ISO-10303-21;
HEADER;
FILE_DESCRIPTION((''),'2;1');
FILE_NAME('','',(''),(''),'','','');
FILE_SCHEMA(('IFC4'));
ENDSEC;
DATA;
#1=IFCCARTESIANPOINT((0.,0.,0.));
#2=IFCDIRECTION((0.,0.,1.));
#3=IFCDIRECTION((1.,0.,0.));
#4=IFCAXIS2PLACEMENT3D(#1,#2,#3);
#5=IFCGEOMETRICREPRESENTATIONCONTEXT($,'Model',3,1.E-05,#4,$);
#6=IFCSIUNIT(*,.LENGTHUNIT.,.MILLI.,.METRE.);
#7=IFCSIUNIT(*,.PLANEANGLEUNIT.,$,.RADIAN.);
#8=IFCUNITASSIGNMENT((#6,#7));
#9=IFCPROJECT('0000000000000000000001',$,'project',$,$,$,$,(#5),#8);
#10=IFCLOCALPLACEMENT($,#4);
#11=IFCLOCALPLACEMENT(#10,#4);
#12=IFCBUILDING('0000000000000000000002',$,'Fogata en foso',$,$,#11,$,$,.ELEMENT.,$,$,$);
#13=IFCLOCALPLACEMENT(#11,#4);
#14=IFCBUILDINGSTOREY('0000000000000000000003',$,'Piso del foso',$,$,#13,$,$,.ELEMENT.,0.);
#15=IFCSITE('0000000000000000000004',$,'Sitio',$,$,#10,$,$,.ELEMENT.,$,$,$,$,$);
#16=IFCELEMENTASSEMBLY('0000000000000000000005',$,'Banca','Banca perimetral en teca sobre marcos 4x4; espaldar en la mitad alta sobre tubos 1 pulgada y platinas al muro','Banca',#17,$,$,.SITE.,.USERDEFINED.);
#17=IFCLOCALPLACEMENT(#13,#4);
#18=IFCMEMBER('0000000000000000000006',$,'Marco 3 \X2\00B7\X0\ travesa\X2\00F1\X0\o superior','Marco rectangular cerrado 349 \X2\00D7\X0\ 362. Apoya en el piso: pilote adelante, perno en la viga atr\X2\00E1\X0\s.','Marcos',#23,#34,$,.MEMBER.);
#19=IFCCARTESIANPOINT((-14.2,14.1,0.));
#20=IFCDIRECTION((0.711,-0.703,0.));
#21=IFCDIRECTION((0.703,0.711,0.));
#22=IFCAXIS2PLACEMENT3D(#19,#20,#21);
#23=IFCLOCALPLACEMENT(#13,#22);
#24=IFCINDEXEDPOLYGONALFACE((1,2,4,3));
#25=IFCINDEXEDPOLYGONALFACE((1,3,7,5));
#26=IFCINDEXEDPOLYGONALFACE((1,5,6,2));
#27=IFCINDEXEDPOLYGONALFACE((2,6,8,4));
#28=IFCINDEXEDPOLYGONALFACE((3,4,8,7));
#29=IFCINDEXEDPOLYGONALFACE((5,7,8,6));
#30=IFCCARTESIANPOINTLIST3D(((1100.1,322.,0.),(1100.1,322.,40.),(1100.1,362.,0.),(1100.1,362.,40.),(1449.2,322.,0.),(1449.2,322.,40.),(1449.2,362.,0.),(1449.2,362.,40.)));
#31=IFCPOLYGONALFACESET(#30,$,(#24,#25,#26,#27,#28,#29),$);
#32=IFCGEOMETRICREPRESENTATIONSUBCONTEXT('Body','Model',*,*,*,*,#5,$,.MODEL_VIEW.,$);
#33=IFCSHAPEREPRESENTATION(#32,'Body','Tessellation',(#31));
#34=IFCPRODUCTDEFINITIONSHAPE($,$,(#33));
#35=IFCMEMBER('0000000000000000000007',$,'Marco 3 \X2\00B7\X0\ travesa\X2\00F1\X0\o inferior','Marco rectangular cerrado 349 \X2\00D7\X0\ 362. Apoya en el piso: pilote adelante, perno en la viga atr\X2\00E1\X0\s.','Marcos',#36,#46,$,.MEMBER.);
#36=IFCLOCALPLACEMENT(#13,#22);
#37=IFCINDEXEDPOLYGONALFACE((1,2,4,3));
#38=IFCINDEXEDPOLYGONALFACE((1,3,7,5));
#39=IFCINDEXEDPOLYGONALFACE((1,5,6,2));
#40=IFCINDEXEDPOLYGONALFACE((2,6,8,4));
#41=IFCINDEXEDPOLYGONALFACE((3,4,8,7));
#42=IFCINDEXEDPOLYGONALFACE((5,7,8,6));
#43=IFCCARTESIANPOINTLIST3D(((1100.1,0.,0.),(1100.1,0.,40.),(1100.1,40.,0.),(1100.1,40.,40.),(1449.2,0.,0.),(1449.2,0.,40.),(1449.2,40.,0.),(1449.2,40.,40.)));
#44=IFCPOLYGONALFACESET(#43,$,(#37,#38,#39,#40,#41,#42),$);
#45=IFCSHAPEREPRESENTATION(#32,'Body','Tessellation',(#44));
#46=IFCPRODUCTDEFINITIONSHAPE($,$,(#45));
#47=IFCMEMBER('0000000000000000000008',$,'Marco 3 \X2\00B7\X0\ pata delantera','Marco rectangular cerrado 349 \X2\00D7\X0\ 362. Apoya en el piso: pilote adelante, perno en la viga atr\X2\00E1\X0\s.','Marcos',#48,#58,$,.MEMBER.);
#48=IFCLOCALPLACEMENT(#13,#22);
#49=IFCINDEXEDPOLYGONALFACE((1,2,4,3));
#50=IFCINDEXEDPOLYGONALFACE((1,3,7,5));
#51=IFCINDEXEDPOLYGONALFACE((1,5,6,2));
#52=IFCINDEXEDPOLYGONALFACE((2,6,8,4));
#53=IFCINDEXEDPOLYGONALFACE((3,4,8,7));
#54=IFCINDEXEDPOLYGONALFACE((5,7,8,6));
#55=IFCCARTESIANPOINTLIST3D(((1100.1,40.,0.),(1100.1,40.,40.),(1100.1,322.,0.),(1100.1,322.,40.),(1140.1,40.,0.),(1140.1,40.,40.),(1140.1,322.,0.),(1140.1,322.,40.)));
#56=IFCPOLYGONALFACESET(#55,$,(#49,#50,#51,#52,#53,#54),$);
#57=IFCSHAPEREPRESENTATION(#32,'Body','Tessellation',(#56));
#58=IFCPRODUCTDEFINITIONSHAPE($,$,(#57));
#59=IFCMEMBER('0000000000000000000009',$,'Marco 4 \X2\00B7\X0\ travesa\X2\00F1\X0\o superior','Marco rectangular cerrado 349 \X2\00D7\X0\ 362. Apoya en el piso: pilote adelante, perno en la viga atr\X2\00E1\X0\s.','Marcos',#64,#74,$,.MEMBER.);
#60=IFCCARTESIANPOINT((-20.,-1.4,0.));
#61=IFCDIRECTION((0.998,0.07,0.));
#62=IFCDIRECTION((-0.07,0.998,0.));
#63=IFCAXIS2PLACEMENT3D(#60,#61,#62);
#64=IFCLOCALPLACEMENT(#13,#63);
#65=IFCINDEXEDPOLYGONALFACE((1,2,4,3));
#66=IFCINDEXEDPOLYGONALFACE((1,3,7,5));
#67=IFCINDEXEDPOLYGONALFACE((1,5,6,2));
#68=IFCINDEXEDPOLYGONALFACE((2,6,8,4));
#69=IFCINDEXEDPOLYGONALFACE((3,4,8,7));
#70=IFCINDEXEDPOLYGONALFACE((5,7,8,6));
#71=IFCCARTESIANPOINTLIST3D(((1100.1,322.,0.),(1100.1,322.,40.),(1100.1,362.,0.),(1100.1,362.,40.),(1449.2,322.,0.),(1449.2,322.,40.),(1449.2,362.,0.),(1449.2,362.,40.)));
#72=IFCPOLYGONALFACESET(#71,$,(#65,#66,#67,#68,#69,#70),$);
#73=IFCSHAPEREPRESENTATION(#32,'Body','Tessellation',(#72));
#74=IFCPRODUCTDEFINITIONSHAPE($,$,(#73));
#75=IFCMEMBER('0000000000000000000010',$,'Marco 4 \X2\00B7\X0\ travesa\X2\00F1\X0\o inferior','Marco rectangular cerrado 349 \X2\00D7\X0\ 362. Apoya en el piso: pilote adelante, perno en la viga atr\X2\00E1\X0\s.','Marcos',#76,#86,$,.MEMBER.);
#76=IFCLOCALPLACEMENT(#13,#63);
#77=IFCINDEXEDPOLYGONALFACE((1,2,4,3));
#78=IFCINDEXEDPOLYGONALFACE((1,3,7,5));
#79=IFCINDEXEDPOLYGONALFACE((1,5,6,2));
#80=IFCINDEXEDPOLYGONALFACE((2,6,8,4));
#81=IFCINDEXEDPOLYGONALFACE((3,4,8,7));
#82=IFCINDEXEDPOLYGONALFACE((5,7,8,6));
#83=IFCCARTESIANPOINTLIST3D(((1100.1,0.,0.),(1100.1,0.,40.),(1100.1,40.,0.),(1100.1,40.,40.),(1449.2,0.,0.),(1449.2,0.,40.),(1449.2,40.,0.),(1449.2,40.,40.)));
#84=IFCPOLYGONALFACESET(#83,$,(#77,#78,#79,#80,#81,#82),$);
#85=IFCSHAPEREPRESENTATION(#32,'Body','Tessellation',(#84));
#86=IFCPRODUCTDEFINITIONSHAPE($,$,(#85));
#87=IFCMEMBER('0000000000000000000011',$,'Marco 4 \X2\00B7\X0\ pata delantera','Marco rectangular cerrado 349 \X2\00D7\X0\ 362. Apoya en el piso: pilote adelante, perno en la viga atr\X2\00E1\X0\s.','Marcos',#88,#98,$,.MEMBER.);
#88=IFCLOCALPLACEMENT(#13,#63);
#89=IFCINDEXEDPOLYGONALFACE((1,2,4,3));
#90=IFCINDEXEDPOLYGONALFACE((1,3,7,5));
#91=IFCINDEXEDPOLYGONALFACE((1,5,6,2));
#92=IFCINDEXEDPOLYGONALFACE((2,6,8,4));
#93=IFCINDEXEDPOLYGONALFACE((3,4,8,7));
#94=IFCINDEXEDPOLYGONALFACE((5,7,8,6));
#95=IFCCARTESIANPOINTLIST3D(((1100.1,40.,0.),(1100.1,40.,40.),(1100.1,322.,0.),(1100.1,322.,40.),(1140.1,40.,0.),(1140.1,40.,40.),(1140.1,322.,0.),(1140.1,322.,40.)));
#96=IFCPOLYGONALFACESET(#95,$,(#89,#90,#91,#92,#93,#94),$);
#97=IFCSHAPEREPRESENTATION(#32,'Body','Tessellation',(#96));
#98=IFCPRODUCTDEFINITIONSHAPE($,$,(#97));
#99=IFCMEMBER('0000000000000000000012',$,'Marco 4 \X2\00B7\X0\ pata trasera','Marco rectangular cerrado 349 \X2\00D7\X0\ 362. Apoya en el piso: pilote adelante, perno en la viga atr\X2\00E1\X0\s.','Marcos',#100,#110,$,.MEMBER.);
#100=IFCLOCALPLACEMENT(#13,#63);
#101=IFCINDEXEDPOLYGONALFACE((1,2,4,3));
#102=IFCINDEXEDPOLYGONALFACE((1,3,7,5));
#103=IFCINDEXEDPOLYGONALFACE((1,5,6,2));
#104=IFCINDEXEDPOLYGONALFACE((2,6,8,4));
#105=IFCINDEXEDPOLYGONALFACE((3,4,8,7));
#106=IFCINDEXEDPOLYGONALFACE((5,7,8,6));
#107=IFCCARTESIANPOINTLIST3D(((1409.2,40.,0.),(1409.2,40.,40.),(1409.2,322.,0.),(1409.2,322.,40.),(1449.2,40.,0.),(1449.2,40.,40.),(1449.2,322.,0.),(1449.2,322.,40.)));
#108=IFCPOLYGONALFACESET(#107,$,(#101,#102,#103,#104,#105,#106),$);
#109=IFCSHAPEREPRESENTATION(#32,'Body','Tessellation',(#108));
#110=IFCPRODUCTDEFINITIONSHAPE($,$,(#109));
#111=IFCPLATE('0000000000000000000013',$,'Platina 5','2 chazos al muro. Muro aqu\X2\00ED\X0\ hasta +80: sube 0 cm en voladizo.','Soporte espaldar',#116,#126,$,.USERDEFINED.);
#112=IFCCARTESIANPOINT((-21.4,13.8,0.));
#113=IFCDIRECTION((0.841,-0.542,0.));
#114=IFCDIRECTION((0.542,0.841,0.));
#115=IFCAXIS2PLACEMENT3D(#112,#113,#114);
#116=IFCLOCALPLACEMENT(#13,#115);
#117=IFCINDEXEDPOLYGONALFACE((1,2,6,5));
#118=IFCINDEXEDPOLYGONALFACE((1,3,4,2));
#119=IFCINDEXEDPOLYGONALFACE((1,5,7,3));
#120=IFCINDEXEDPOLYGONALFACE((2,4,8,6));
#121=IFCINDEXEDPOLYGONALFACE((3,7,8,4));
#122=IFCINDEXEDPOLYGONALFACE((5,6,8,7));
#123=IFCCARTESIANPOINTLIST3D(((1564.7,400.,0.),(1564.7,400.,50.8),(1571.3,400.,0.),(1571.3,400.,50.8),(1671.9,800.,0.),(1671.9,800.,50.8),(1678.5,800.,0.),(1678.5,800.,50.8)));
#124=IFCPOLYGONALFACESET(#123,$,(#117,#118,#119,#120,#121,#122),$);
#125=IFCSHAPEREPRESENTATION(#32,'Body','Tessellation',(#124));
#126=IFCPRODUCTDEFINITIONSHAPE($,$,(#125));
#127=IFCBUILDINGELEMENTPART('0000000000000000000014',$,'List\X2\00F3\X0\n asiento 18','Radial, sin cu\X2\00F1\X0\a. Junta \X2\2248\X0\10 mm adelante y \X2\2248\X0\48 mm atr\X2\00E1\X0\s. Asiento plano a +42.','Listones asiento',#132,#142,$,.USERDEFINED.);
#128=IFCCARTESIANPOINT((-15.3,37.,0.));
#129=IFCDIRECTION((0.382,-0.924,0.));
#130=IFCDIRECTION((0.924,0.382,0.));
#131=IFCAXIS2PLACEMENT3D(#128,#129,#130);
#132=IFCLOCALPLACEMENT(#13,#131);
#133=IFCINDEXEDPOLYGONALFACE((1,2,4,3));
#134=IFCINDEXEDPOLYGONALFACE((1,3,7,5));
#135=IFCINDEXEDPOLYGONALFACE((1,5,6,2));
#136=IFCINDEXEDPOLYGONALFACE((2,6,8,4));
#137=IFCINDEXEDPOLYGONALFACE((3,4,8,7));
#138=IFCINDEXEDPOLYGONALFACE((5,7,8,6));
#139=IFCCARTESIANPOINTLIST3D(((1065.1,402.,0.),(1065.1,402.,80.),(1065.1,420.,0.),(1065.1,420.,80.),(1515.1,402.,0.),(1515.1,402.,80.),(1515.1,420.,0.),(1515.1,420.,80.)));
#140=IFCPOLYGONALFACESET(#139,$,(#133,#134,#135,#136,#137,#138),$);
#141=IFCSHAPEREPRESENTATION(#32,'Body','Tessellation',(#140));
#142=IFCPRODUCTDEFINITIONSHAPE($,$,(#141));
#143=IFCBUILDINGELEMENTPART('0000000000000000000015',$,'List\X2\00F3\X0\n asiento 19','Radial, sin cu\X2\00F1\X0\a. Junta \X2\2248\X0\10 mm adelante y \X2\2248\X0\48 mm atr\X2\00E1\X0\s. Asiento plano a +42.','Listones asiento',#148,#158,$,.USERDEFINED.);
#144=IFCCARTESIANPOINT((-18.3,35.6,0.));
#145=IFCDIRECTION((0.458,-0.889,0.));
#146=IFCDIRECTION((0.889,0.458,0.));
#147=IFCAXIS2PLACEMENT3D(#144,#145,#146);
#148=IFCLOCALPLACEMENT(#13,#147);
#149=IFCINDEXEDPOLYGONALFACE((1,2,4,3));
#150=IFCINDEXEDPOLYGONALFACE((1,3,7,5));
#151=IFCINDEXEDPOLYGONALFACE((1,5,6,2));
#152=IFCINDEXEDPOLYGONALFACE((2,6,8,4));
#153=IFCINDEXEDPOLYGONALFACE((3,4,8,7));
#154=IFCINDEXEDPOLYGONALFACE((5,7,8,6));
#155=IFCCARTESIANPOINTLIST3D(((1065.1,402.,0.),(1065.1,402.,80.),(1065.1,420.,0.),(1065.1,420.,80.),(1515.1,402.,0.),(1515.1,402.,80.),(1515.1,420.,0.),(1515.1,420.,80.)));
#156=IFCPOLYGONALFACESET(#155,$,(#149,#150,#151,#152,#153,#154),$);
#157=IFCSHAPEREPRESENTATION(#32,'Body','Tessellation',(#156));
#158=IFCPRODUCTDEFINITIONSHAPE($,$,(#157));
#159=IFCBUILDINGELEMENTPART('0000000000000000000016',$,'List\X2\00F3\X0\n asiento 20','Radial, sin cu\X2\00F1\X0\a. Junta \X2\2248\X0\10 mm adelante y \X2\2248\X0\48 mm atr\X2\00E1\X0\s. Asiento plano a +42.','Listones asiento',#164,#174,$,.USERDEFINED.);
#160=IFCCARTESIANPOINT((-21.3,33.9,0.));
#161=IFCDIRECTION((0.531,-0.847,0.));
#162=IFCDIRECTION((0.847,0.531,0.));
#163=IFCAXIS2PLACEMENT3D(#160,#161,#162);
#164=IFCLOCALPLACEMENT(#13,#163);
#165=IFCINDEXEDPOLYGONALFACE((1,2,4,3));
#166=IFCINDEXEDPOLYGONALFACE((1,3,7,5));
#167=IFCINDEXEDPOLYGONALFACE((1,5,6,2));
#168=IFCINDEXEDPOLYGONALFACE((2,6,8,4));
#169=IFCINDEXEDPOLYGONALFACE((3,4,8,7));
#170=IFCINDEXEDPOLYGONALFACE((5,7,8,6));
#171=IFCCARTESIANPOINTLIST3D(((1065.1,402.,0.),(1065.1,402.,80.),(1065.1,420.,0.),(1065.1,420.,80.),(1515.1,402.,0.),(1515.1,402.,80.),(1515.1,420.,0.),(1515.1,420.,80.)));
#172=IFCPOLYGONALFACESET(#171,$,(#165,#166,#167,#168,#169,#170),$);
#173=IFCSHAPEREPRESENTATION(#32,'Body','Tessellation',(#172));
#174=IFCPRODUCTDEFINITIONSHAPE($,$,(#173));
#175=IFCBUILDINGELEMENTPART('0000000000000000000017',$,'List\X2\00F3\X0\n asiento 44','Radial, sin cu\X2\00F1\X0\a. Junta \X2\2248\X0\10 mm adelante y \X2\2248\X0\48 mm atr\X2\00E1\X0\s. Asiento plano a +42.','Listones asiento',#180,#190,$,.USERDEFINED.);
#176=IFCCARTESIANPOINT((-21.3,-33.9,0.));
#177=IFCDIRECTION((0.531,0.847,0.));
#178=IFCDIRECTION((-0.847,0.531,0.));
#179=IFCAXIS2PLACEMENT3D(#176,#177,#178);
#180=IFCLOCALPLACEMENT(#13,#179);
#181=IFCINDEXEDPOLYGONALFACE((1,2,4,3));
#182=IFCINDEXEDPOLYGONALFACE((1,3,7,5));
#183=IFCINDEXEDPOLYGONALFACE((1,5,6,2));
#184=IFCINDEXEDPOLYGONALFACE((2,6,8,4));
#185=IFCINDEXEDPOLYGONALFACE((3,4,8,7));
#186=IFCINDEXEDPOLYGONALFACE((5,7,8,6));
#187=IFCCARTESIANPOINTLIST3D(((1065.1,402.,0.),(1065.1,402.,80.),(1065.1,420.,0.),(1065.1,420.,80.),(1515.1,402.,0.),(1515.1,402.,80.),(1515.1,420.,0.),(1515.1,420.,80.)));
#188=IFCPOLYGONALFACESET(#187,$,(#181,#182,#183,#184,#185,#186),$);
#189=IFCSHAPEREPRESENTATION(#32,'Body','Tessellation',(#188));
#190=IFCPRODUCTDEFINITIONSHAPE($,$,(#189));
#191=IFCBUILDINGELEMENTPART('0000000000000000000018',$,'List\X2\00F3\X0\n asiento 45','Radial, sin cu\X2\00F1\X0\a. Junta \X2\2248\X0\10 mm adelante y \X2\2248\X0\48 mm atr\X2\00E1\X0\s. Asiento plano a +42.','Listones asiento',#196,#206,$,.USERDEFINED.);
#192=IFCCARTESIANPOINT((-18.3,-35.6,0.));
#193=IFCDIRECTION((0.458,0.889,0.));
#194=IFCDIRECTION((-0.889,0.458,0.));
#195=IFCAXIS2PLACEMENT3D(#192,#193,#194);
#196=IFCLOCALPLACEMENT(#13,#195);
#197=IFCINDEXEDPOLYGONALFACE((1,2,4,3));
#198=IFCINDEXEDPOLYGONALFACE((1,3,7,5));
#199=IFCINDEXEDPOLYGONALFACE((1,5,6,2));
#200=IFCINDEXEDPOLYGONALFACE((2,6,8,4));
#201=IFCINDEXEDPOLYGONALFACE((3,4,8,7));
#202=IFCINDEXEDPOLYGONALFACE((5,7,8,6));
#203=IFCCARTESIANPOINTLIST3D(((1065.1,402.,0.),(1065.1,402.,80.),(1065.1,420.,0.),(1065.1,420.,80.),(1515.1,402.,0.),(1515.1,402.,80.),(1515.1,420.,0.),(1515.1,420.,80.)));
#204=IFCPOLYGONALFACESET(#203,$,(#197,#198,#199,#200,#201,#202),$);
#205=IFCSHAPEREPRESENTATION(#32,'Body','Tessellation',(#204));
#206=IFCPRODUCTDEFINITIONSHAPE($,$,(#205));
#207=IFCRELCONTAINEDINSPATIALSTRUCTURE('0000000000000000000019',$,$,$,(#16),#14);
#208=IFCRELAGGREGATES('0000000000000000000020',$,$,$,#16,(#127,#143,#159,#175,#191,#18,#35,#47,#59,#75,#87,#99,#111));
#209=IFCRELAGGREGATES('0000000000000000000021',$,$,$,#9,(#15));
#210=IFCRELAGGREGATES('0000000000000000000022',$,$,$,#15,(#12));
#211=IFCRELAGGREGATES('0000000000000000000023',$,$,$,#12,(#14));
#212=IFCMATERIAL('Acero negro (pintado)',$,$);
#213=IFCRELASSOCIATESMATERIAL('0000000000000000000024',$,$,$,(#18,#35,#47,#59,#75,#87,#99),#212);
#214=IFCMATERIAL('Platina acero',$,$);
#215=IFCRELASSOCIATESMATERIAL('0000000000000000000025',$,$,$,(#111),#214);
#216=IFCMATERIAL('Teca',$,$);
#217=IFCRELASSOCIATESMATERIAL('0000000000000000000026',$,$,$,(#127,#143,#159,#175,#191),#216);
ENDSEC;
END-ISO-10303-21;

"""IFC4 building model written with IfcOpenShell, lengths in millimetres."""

from ifc_helpers import new_model, si_unit, frame, origin_with_axes, place, context, subcontext, project, spatial, polyline, outline, extrude, material, element, aggregate, save


model = new_model("IFC4")

# Units and contexts
model_context = context("Model", 3, precision=1e-05, world=origin_with_axes())
body_context = subcontext(model_context, "Body", "Model", "MODEL_VIEW")
ifc_project = project(units=[si_unit("LENGTHUNIT", "METRE", prefix="MILLI"), si_unit("PLANEANGLEUNIT", "RADIAN")], contexts=[model_context])

# Site, building, storey
site_placement = place(None, origin_with_axes())
site = spatial("IfcSite", under=ifc_project, at=site_placement, Name="Sitio", CompositionType="ELEMENT")
building_placement = place(site_placement, origin_with_axes())
building = spatial("IfcBuilding", under=site, at=building_placement, Name="Fogata en foso", CompositionType="ELEMENT")
storey_placement = place(building_placement, origin_with_axes())
storey = spatial("IfcBuildingStorey", under=building, at=storey_placement, Name="Piso del foso", CompositionType="ELEMENT", Elevation=0.0)

# Element assembly, members, plate, building element parts
assembly_placement = place(storey_placement, origin_with_axes())
assembly = element("IfcElementAssembly", 1, at=assembly_placement, inside=storey, Name="Banca", Description="Banca perimetral en teca sobre marcos 4x4; espaldar en la mitad alta sobre tubos 1 pulgada y platinas al muro", ObjectType="Banca", AssemblyPlace="SITE", PredefinedType="USERDEFINED")
ifc_material_1 = material(Name="Acero negro (pintado)")
member_1_placement = place(storey_placement, frame((-14.2, 14.1, 0.0), z_axis=(0.711, -0.703, 0.0), x_axis=(0.703, 0.711, 0.0)))
member_1 = element("IfcMember", 2, at=member_1_placement, material=ifc_material_1, Name="Marco 3 · travesaño superior", Description="Marco rectangular cerrado 349 × 362. Apoya en el piso: pilote adelante, perno en la viga atrás.", ObjectType="Marcos", PredefinedType="MEMBER", context=body_context, shape_type="SweptSolid", body=[
    extrude(outline(polyline([(1100.1, 322.0), (1449.2, 322.0), (1449.2, 362.0), (1100.1, 362.0), (1100.1, 322.0)])), origin_with_axes(), (0.0, 0.0, 1.0), 40.0),
])
member_2_placement = place(storey_placement, frame((-14.2, 14.1, 0.0), z_axis=(0.711, -0.703, 0.0), x_axis=(0.703, 0.711, 0.0)))
member_2 = element("IfcMember", 3, at=member_2_placement, material=ifc_material_1, Name="Marco 3 · travesaño inferior", Description="Marco rectangular cerrado 349 × 362. Apoya en el piso: pilote adelante, perno en la viga atrás.", ObjectType="Marcos", PredefinedType="MEMBER", context=body_context, shape_type="SweptSolid", body=[
    extrude(outline(polyline([(1100.1, 0.0), (1449.2, 0.0), (1449.2, 40.0), (1100.1, 40.0), (1100.1, 0.0)])), origin_with_axes(), (0.0, 0.0, 1.0), 40.0),
])
member_3_placement = place(storey_placement, frame((-14.2, 14.1, 0.0), z_axis=(0.711, -0.703, 0.0), x_axis=(0.703, 0.711, 0.0)))
member_3 = element("IfcMember", 4, at=member_3_placement, material=ifc_material_1, Name="Marco 3 · pata delantera", Description="Marco rectangular cerrado 349 × 362. Apoya en el piso: pilote adelante, perno en la viga atrás.", ObjectType="Marcos", PredefinedType="MEMBER", context=body_context, shape_type="SweptSolid", body=[
    extrude(outline(polyline([(1100.1, 40.0), (1140.1, 40.0), (1140.1, 322.0), (1100.1, 322.0), (1100.1, 40.0)])), origin_with_axes(), (0.0, 0.0, 1.0), 40.0),
])
member_4_placement = place(storey_placement, frame((-20.0, -1.4, 0.0), z_axis=(0.998, 0.07, 0.0), x_axis=(-0.07, 0.998, 0.0)))
member_4 = element("IfcMember", 5, at=member_4_placement, material=ifc_material_1, Name="Marco 4 · travesaño superior", Description="Marco rectangular cerrado 349 × 362. Apoya en el piso: pilote adelante, perno en la viga atrás.", ObjectType="Marcos", PredefinedType="MEMBER", context=body_context, shape_type="SweptSolid", body=[
    extrude(outline(polyline([(1100.1, 322.0), (1449.2, 322.0), (1449.2, 362.0), (1100.1, 362.0), (1100.1, 322.0)])), origin_with_axes(), (0.0, 0.0, 1.0), 40.0),
])
member_5_placement = place(storey_placement, frame((-20.0, -1.4, 0.0), z_axis=(0.998, 0.07, 0.0), x_axis=(-0.07, 0.998, 0.0)))
member_5 = element("IfcMember", 6, at=member_5_placement, material=ifc_material_1, Name="Marco 4 · travesaño inferior", Description="Marco rectangular cerrado 349 × 362. Apoya en el piso: pilote adelante, perno en la viga atrás.", ObjectType="Marcos", PredefinedType="MEMBER", context=body_context, shape_type="SweptSolid", body=[
    extrude(outline(polyline([(1100.1, 0.0), (1449.2, 0.0), (1449.2, 40.0), (1100.1, 40.0), (1100.1, 0.0)])), origin_with_axes(), (0.0, 0.0, 1.0), 40.0),
])
member_6_placement = place(storey_placement, frame((-20.0, -1.4, 0.0), z_axis=(0.998, 0.07, 0.0), x_axis=(-0.07, 0.998, 0.0)))
member_6 = element("IfcMember", 7, at=member_6_placement, material=ifc_material_1, Name="Marco 4 · pata delantera", Description="Marco rectangular cerrado 349 × 362. Apoya en el piso: pilote adelante, perno en la viga atrás.", ObjectType="Marcos", PredefinedType="MEMBER", context=body_context, shape_type="SweptSolid", body=[
    extrude(outline(polyline([(1100.1, 40.0), (1140.1, 40.0), (1140.1, 322.0), (1100.1, 322.0), (1100.1, 40.0)])), origin_with_axes(), (0.0, 0.0, 1.0), 40.0),
])
member_7_placement = place(storey_placement, frame((-20.0, -1.4, 0.0), z_axis=(0.998, 0.07, 0.0), x_axis=(-0.07, 0.998, 0.0)))
member_7 = element("IfcMember", 8, at=member_7_placement, material=ifc_material_1, Name="Marco 4 · pata trasera", Description="Marco rectangular cerrado 349 × 362. Apoya en el piso: pilote adelante, perno en la viga atrás.", ObjectType="Marcos", PredefinedType="MEMBER", context=body_context, shape_type="SweptSolid", body=[
    extrude(outline(polyline([(1409.2, 40.0), (1449.2, 40.0), (1449.2, 322.0), (1409.2, 322.0), (1409.2, 40.0)])), origin_with_axes(), (0.0, 0.0, 1.0), 40.0),
])
ifc_material_2 = material(Name="Platina acero")
plate_placement = place(storey_placement, frame((-21.4, 13.8, 0.0), z_axis=(0.841, -0.542, 0.0), x_axis=(0.542, 0.841, 0.0)))
plate = element("IfcPlate", 9, at=plate_placement, material=ifc_material_2, Name="Platina 5", Description="2 chazos al muro. Muro aquí hasta +80: sube 0 cm en voladizo.", ObjectType="Soporte espaldar", PredefinedType="USERDEFINED", context=body_context, shape_type="SweptSolid", body=[
    extrude(outline(polyline([(1564.7, 400.0), (1571.3, 400.0), (1678.5, 800.0), (1671.9, 800.0), (1564.7, 400.0)])), origin_with_axes(), (0.0, 0.0, 1.0), 50.8),
])
ifc_material_3 = material(Name="Teca")
building_element_part_1_placement = place(storey_placement, frame((-15.3, 37.0, 0.0), z_axis=(0.382, -0.924, 0.0), x_axis=(0.924, 0.382, 0.0)))
building_element_part_1 = element("IfcBuildingElementPart", 10, at=building_element_part_1_placement, material=ifc_material_3, Name="Listón asiento 18", Description="Radial, sin cuña. Junta ≈10 mm adelante y ≈48 mm atrás. Asiento plano a +42.", ObjectType="Listones asiento", PredefinedType="USERDEFINED", context=body_context, shape_type="SweptSolid", body=[
    extrude(outline(polyline([(1065.1, 402.0), (1515.1, 402.0), (1515.1, 420.0), (1065.1, 420.0), (1065.1, 402.0)])), origin_with_axes(), (0.0, 0.0, 1.0), 80.0),
])
building_element_part_2_placement = place(storey_placement, frame((-18.3, 35.6, 0.0), z_axis=(0.458, -0.889, 0.0), x_axis=(0.889, 0.458, 0.0)))
building_element_part_2 = element("IfcBuildingElementPart", 11, at=building_element_part_2_placement, material=ifc_material_3, Name="Listón asiento 19", Description="Radial, sin cuña. Junta ≈10 mm adelante y ≈48 mm atrás. Asiento plano a +42.", ObjectType="Listones asiento", PredefinedType="USERDEFINED", context=body_context, shape_type="SweptSolid", body=[
    extrude(outline(polyline([(1065.1, 402.0), (1515.1, 402.0), (1515.1, 420.0), (1065.1, 420.0), (1065.1, 402.0)])), origin_with_axes(), (0.0, 0.0, 1.0), 80.0),
])
building_element_part_3_placement = place(storey_placement, frame((-21.3, 33.9, 0.0), z_axis=(0.531, -0.847, 0.0), x_axis=(0.847, 0.531, 0.0)))
building_element_part_3 = element("IfcBuildingElementPart", 12, at=building_element_part_3_placement, material=ifc_material_3, Name="Listón asiento 20", Description="Radial, sin cuña. Junta ≈10 mm adelante y ≈48 mm atrás. Asiento plano a +42.", ObjectType="Listones asiento", PredefinedType="USERDEFINED", context=body_context, shape_type="SweptSolid", body=[
    extrude(outline(polyline([(1065.1, 402.0), (1515.1, 402.0), (1515.1, 420.0), (1065.1, 420.0), (1065.1, 402.0)])), origin_with_axes(), (0.0, 0.0, 1.0), 80.0),
])
building_element_part_4_placement = place(storey_placement, frame((-21.3, -33.9, 0.0), z_axis=(0.531, 0.847, 0.0), x_axis=(-0.847, 0.531, 0.0)))
building_element_part_4 = element("IfcBuildingElementPart", 13, at=building_element_part_4_placement, material=ifc_material_3, Name="Listón asiento 44", Description="Radial, sin cuña. Junta ≈10 mm adelante y ≈48 mm atrás. Asiento plano a +42.", ObjectType="Listones asiento", PredefinedType="USERDEFINED", context=body_context, shape_type="SweptSolid", body=[
    extrude(outline(polyline([(1065.1, 402.0), (1515.1, 402.0), (1515.1, 420.0), (1065.1, 420.0), (1065.1, 402.0)])), origin_with_axes(), (0.0, 0.0, 1.0), 80.0),
])
building_element_part_5_placement = place(storey_placement, frame((-18.3, -35.6, 0.0), z_axis=(0.458, 0.889, 0.0), x_axis=(-0.889, 0.458, 0.0)))
building_element_part_5 = element("IfcBuildingElementPart", 14, at=building_element_part_5_placement, material=ifc_material_3, Name="Listón asiento 45", Description="Radial, sin cuña. Junta ≈10 mm adelante y ≈48 mm atrás. Asiento plano a +42.", ObjectType="Listones asiento", PredefinedType="USERDEFINED", context=body_context, shape_type="SweptSolid", body=[
    extrude(outline(polyline([(1065.1, 402.0), (1515.1, 402.0), (1515.1, 420.0), (1065.1, 420.0), (1065.1, 402.0)])), origin_with_axes(), (0.0, 0.0, 1.0), 80.0),
])
aggregate(assembly, [building_element_part_1, building_element_part_2, building_element_part_3, building_element_part_4, building_element_part_5, member_1, member_2, member_3, member_4, member_5, member_6, member_7, plate])

save(model, "model.ifc")
